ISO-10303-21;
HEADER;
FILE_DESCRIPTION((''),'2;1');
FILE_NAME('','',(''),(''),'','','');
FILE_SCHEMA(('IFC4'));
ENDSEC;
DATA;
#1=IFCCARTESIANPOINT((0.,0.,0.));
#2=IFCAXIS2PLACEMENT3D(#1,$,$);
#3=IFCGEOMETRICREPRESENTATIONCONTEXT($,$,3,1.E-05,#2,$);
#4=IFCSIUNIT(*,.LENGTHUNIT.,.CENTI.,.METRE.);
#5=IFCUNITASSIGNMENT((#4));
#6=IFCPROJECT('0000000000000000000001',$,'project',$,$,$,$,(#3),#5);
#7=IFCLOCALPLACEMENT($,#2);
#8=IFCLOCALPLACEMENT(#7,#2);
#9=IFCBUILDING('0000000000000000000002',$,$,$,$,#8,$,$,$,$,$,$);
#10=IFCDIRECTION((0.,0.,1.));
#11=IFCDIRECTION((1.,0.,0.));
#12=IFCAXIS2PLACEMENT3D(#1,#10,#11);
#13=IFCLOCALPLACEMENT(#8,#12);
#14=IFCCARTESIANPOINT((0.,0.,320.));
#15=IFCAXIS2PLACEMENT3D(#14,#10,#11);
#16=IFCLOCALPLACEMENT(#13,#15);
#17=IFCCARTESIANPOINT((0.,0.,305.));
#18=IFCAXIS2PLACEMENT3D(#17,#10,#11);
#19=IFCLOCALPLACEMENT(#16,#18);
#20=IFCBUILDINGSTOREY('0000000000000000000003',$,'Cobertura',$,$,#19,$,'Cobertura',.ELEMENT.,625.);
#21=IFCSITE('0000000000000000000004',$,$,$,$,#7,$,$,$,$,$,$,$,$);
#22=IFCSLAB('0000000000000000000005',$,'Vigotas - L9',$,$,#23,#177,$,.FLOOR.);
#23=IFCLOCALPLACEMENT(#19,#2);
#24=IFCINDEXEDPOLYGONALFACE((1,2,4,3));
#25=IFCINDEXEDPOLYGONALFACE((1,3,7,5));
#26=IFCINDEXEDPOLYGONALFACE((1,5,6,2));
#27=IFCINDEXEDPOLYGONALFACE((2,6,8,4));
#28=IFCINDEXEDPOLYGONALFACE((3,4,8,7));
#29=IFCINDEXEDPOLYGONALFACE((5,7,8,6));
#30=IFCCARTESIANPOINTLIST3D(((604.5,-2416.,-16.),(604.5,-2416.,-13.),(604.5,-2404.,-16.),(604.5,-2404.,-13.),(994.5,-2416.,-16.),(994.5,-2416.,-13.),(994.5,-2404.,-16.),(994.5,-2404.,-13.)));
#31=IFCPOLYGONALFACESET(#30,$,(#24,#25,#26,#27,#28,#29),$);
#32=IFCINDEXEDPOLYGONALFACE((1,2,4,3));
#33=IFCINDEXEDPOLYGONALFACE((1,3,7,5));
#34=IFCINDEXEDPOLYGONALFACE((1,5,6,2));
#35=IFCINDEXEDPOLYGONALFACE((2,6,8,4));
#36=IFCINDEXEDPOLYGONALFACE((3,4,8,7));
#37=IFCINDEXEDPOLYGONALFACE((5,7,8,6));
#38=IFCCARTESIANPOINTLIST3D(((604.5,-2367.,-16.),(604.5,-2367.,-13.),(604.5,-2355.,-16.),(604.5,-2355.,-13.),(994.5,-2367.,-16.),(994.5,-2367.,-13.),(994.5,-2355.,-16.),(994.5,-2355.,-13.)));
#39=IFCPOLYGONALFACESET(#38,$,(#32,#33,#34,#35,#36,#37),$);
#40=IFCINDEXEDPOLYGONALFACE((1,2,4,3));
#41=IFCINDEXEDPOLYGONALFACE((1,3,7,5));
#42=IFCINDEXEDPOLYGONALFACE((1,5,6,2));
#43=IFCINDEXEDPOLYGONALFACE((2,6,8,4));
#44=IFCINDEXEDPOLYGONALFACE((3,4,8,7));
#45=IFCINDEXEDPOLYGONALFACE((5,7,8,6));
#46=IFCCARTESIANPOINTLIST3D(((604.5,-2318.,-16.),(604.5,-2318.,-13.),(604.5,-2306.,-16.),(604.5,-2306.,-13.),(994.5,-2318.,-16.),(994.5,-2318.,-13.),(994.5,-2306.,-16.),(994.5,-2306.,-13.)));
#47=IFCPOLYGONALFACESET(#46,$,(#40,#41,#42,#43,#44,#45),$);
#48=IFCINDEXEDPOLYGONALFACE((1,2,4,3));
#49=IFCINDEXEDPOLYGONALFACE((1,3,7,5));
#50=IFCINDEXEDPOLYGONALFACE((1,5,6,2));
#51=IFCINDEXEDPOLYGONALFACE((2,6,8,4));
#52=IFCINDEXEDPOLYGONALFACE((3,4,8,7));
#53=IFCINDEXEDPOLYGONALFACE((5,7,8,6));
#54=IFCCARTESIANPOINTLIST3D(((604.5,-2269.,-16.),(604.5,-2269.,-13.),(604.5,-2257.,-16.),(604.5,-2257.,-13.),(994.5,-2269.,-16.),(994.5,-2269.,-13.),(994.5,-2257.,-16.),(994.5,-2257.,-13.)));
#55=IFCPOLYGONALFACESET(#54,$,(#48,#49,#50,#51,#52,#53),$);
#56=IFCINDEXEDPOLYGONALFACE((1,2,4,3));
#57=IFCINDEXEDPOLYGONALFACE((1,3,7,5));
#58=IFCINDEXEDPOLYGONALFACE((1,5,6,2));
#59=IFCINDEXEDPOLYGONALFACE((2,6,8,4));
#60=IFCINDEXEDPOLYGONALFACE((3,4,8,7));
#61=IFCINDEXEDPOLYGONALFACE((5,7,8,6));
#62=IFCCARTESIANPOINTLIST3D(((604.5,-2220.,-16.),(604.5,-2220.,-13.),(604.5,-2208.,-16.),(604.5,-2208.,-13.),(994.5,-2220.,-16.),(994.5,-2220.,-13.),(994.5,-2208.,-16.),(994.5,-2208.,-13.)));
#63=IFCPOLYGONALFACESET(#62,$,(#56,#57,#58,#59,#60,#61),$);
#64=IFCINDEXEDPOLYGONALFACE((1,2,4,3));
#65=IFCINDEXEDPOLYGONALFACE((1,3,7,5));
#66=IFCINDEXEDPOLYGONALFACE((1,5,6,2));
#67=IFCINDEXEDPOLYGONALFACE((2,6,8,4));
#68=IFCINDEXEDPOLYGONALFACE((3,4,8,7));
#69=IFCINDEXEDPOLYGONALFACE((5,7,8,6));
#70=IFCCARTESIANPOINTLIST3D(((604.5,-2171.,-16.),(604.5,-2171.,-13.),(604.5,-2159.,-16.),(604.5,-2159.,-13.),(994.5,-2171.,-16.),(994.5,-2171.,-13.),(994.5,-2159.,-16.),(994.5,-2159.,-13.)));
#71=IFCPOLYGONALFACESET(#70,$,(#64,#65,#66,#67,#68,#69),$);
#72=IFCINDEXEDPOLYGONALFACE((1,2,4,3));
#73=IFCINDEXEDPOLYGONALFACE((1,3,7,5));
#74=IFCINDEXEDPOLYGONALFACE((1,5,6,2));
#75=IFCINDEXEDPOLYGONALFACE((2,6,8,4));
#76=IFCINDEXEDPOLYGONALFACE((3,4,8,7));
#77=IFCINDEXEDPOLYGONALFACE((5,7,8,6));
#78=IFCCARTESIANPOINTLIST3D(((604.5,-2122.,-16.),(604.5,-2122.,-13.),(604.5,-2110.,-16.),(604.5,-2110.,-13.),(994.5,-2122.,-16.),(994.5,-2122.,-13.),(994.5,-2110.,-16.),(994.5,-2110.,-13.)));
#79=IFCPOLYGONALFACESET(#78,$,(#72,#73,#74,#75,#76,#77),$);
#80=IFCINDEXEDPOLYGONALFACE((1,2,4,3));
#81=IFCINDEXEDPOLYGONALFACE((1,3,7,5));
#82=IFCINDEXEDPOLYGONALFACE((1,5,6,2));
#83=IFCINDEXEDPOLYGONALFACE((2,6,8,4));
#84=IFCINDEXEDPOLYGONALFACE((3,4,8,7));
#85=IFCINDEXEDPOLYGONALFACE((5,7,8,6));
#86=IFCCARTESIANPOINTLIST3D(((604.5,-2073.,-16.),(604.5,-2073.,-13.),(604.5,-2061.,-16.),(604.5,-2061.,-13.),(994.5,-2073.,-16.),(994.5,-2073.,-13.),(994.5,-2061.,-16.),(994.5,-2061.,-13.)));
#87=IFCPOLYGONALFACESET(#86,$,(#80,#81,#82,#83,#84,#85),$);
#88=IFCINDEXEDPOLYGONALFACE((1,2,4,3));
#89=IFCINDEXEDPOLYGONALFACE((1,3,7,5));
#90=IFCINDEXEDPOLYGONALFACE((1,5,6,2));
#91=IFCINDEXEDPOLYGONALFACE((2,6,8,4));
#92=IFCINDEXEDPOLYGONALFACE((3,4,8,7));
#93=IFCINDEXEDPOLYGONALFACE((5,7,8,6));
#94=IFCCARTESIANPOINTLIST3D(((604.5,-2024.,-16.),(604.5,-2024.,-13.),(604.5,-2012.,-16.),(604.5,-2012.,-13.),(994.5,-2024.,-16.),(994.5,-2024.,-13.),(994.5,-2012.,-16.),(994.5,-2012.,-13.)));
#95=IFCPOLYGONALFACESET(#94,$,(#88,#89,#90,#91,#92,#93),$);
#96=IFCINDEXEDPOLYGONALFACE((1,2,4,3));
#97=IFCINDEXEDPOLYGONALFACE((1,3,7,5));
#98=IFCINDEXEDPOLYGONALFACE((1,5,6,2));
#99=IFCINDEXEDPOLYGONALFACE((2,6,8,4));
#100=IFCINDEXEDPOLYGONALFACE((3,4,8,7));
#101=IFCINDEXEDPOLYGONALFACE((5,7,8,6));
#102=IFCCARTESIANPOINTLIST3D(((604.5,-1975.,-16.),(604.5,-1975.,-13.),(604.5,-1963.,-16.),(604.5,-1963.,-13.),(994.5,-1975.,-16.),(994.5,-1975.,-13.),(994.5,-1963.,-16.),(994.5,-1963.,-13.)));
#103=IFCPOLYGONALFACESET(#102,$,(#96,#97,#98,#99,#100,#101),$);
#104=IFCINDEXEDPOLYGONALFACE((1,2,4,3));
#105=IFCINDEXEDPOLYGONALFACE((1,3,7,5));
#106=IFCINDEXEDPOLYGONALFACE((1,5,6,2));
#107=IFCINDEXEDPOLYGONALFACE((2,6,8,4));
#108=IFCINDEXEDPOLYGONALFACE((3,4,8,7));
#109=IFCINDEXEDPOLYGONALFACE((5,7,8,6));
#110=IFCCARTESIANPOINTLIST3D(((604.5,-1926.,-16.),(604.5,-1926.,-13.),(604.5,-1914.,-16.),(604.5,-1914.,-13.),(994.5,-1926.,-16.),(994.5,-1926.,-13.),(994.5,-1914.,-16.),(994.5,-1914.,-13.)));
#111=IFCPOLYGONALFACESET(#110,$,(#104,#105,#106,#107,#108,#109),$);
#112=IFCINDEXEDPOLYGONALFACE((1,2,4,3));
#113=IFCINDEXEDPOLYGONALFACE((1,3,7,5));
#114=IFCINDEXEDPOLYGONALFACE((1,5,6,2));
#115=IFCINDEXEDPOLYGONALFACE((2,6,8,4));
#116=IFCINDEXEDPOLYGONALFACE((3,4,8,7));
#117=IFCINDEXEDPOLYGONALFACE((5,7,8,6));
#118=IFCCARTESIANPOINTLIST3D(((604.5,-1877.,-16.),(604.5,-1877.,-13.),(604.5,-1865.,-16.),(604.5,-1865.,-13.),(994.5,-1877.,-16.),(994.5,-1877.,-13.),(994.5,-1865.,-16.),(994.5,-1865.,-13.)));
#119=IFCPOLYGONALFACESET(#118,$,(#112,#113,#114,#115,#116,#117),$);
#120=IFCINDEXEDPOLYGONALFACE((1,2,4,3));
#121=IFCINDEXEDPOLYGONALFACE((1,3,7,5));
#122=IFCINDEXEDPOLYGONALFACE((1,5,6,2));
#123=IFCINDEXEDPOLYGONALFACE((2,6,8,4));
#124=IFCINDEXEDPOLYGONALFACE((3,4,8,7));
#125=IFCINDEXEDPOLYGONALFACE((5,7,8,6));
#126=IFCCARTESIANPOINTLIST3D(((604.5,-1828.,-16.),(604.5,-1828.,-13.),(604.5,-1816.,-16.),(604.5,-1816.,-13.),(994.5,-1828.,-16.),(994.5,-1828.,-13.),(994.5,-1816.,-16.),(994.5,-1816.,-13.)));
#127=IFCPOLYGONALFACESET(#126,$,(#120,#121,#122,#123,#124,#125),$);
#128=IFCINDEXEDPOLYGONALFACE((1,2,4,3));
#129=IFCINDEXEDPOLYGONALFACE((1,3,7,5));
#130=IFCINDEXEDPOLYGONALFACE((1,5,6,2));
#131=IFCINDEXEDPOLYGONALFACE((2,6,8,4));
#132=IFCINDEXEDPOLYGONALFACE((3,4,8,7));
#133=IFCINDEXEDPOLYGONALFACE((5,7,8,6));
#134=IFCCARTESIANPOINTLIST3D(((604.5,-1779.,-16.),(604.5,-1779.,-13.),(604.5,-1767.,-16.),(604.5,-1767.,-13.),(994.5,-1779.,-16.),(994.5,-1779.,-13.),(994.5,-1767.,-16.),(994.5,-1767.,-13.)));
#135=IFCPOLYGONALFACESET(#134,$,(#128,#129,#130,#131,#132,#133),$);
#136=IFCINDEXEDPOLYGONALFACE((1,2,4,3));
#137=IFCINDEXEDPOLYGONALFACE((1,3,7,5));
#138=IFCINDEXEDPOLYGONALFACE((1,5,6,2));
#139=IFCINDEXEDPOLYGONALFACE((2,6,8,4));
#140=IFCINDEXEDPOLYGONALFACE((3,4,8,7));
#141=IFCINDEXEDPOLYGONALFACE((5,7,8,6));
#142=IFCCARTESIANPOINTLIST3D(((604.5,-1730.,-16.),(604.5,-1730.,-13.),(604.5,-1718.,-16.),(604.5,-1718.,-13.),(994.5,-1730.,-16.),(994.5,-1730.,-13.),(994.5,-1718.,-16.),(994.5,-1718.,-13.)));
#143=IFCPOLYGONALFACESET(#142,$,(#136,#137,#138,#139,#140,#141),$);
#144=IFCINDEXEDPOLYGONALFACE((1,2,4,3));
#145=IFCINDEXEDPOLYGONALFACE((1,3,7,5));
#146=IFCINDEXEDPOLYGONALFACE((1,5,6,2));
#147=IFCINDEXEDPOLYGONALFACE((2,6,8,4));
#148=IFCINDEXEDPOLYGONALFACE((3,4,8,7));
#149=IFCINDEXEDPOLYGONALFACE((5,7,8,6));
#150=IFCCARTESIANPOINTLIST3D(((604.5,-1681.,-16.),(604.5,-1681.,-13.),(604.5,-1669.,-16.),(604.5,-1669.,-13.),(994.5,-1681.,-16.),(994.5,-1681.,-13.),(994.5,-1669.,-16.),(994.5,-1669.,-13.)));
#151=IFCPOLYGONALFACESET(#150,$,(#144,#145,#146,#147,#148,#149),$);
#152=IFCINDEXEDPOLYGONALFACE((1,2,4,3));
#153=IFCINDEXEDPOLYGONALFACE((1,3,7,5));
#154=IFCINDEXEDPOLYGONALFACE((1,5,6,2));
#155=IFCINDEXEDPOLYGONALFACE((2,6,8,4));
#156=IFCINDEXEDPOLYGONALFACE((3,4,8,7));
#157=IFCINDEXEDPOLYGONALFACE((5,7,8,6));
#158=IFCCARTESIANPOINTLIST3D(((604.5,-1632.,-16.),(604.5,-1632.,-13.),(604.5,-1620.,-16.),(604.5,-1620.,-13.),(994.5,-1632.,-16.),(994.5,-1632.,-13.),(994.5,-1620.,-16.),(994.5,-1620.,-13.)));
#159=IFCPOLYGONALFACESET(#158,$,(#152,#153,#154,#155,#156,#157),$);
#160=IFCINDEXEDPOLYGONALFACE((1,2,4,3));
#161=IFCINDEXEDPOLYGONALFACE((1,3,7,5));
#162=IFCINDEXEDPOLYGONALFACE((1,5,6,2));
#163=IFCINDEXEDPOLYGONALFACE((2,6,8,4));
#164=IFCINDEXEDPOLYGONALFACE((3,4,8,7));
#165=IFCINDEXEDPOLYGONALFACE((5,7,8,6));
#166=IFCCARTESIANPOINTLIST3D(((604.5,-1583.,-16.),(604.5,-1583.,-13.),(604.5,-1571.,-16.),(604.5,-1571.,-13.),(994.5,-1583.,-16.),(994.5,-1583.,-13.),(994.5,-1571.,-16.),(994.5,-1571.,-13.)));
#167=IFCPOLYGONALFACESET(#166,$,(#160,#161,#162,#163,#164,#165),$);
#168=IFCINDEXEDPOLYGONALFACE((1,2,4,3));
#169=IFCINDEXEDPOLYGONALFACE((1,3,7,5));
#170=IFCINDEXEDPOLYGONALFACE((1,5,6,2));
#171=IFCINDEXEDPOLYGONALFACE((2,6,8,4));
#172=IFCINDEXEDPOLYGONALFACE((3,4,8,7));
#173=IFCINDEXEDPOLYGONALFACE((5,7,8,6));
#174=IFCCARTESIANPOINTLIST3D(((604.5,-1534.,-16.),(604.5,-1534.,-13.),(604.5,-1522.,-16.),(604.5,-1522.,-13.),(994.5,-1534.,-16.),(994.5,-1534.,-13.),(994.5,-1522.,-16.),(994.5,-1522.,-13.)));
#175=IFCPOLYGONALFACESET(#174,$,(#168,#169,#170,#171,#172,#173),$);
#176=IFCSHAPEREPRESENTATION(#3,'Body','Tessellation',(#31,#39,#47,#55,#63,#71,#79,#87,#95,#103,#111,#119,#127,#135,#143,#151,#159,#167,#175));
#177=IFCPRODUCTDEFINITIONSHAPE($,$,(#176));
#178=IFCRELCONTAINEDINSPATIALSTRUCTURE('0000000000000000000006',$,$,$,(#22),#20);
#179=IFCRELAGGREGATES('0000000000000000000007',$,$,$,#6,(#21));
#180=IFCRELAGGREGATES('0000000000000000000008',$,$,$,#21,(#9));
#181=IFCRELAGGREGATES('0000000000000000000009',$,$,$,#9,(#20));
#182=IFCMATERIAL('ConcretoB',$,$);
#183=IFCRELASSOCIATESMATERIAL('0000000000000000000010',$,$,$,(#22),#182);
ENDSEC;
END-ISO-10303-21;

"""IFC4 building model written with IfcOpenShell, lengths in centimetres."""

from ifc_helpers import new_model, si_unit, frame, origin, origin_with_axes, place, context, project, spatial, polyline, outline, extrude, material, element, save


model = new_model("IFC4")

# Units and contexts
context_of_model = context(None, 3, precision=1e-05, world=origin())
ifc_project = project(units=[si_unit("LENGTHUNIT", "METRE", prefix="CENTI")], contexts=[context_of_model])

# Site, building, storey
site_placement = place(None, origin())
site = spatial("IfcSite", under=ifc_project, at=site_placement)
building_placement = place(site_placement, origin())
building = spatial("IfcBuilding", under=site, at=building_placement)
placement_1 = place(building_placement, origin_with_axes())
placement_2 = place(placement_1, frame((0.0, 0.0, 320.0), z_axis=(0.0, 0.0, 1.0), x_axis=(1.0, 0.0, 0.0)))
storey_placement = place(placement_2, frame((0.0, 0.0, 305.0), z_axis=(0.0, 0.0, 1.0), x_axis=(1.0, 0.0, 0.0)))
storey = spatial("IfcBuildingStorey", under=building, at=storey_placement, Name="Cobertura", LongName="Cobertura", CompositionType="ELEMENT", Elevation=625.0)

# Shared definitions
ifc_material_1 = material(Name="ConcretoB")

# Slab
slab_1_placement = place(storey_placement, frame((799.5, -1969.0, -13.0), z_axis=(0.0, 0.0, 1.0), x_axis=(1.0, 0.0, 0.0)))
element("IfcSlab", 1, at=slab_1_placement, inside=storey, material=ifc_material_1, Name="Vigotas - L9", PredefinedType="FLOOR", context=context_of_model, shape_type="SolidModel", body=[
    extrude(outline(polyline([(6.0, 1.5), (-6.0, 1.5), (-6.0, -1.5), (6.0, -1.5), (6.0, 1.5), (6.0, 1.5)])), frame((-195.0, -441.0, -1.5), z_axis=(1.0, 0.0, 0.0), x_axis=(0.0, -1.0, 0.0)), (0.0, 0.0, 1.0), 390.0),
    extrude(outline(polyline([(6.0, 1.5), (-6.0, 1.5), (-6.0, -1.5), (6.0, -1.5), (6.0, 1.5), (6.0, 1.5)])), frame((-195.0, -392.0, -1.5), z_axis=(1.0, 0.0, 0.0), x_axis=(0.0, -1.0, 0.0)), (0.0, 0.0, 1.0), 390.0),
    extrude(outline(polyline([(6.0, 1.5), (-6.0, 1.5), (-6.0, -1.5), (6.0, -1.5), (6.0, 1.5), (6.0, 1.5)])), frame((-195.0, -343.0, -1.5), z_axis=(1.0, 0.0, 0.0), x_axis=(0.0, -1.0, 0.0)), (0.0, 0.0, 1.0), 390.0),
    extrude(outline(polyline([(6.0, 1.5), (-6.0, 1.5), (-6.0, -1.5), (6.0, -1.5), (6.0, 1.5), (6.0, 1.5)])), frame((-195.0, -294.0, -1.5), z_axis=(1.0, 0.0, 0.0), x_axis=(0.0, -1.0, 0.0)), (0.0, 0.0, 1.0), 390.0),
    extrude(outline(polyline([(6.0, 1.5), (-6.0, 1.5), (-6.0, -1.5), (6.0, -1.5), (6.0, 1.5), (6.0, 1.5)])), frame((-195.0, -245.0, -1.5), z_axis=(1.0, 0.0, 0.0), x_axis=(0.0, -1.0, 0.0)), (0.0, 0.0, 1.0), 390.0),
    extrude(outline(polyline([(6.0, 1.5), (-6.0, 1.5), (-6.0, -1.5), (6.0, -1.5), (6.0, 1.5), (6.0, 1.5)])), frame((-195.0, -196.0, -1.5), z_axis=(1.0, 0.0, 0.0), x_axis=(0.0, -1.0, 0.0)), (0.0, 0.0, 1.0), 390.0),
    extrude(outline(polyline([(6.0, 1.5), (-6.0, 1.5), (-6.0, -1.5), (6.0, -1.5), (6.0, 1.5), (6.0, 1.5)])), frame((-195.0, -147.0, -1.5), z_axis=(1.0, 0.0, 0.0), x_axis=(0.0, -1.0, 0.0)), (0.0, 0.0, 1.0), 390.0),
    extrude(outline(polyline([(6.0, 1.5), (-6.0, 1.5), (-6.0, -1.5), (6.0, -1.5), (6.0, 1.5), (6.0, 1.5)])), frame((-195.0, -98.0, -1.5), z_axis=(1.0, 0.0, 0.0), x_axis=(0.0, -1.0, 0.0)), (0.0, 0.0, 1.0), 390.0),
    extrude(outline(polyline([(6.0, 1.5), (-6.0, 1.5), (-6.0, -1.5), (6.0, -1.5), (6.0, 1.5), (6.0, 1.5)])), frame((-195.0, -49.0, -1.5), z_axis=(1.0, 0.0, 0.0), x_axis=(0.0, -1.0, 0.0)), (0.0, 0.0, 1.0), 390.0),
    extrude(outline(polyline([(6.0, 1.5), (-6.0, 1.5), (-6.0, -1.5), (6.0, -1.5), (6.0, 1.5), (6.0, 1.5)])), frame((-195.0, 0.0, -1.5), z_axis=(1.0, 0.0, 0.0), x_axis=(0.0, -1.0, 0.0)), (0.0, 0.0, 1.0), 390.0),
    extrude(outline(polyline([(6.0, 1.5), (-6.0, 1.5), (-6.0, -1.5), (6.0, -1.5), (6.0, 1.5), (6.0, 1.5)])), frame((-195.0, 49.0, -1.5), z_axis=(1.0, 0.0, 0.0), x_axis=(0.0, -1.0, 0.0)), (0.0, 0.0, 1.0), 390.0),
    extrude(outline(polyline([(6.0, 1.5), (-6.0, 1.5), (-6.0, -1.5), (6.0, -1.5), (6.0, 1.5), (6.0, 1.5)])), frame((-195.0, 98.0, -1.5), z_axis=(1.0, 0.0, 0.0), x_axis=(0.0, -1.0, 0.0)), (0.0, 0.0, 1.0), 390.0),
    extrude(outline(polyline([(6.0, 1.5), (-6.0, 1.5), (-6.0, -1.5), (6.0, -1.5), (6.0, 1.5), (6.0, 1.5)])), frame((-195.0, 147.0, -1.5), z_axis=(1.0, 0.0, 0.0), x_axis=(0.0, -1.0, 0.0)), (0.0, 0.0, 1.0), 390.0),
    extrude(outline(polyline([(6.0, 1.5), (-6.0, 1.5), (-6.0, -1.5), (6.0, -1.5), (6.0, 1.5), (6.0, 1.5)])), frame((-195.0, 196.0, -1.5), z_axis=(1.0, 0.0, 0.0), x_axis=(0.0, -1.0, 0.0)), (0.0, 0.0, 1.0), 390.0),
    extrude(outline(polyline([(6.0, 1.5), (-6.0, 1.5), (-6.0, -1.5), (6.0, -1.5), (6.0, 1.5), (6.0, 1.5)])), frame((-195.0, 245.0, -1.5), z_axis=(1.0, 0.0, 0.0), x_axis=(0.0, -1.0, 0.0)), (0.0, 0.0, 1.0), 390.0),
    extrude(outline(polyline([(6.0, 1.5), (-6.0, 1.5), (-6.0, -1.5), (6.0, -1.5), (6.0, 1.5), (6.0, 1.5)])), frame((-195.0, 294.0, -1.5), z_axis=(1.0, 0.0, 0.0), x_axis=(0.0, -1.0, 0.0)), (0.0, 0.0, 1.0), 390.0),
    extrude(outline(polyline([(6.0, 1.5), (-6.0, 1.5), (-6.0, -1.5), (6.0, -1.5), (6.0, 1.5), (6.0, 1.5)])), frame((-195.0, 343.0, -1.5), z_axis=(1.0, 0.0, 0.0), x_axis=(0.0, -1.0, 0.0)), (0.0, 0.0, 1.0), 390.0),
    extrude(outline(polyline([(6.0, 1.5), (-6.0, 1.5), (-6.0, -1.5), (6.0, -1.5), (6.0, 1.5), (6.0, 1.5)])), frame((-195.0, 392.0, -1.5), z_axis=(1.0, 0.0, 0.0), x_axis=(0.0, -1.0, 0.0)), (0.0, 0.0, 1.0), 390.0),
    extrude(outline(polyline([(6.0, 1.5), (-6.0, 1.5), (-6.0, -1.5), (6.0, -1.5), (6.0, 1.5), (6.0, 1.5)])), frame((-195.0, 441.0, -1.5), z_axis=(1.0, 0.0, 0.0), x_axis=(0.0, -1.0, 0.0)), (0.0, 0.0, 1.0), 390.0),
])

save(model, "model.ifc")
